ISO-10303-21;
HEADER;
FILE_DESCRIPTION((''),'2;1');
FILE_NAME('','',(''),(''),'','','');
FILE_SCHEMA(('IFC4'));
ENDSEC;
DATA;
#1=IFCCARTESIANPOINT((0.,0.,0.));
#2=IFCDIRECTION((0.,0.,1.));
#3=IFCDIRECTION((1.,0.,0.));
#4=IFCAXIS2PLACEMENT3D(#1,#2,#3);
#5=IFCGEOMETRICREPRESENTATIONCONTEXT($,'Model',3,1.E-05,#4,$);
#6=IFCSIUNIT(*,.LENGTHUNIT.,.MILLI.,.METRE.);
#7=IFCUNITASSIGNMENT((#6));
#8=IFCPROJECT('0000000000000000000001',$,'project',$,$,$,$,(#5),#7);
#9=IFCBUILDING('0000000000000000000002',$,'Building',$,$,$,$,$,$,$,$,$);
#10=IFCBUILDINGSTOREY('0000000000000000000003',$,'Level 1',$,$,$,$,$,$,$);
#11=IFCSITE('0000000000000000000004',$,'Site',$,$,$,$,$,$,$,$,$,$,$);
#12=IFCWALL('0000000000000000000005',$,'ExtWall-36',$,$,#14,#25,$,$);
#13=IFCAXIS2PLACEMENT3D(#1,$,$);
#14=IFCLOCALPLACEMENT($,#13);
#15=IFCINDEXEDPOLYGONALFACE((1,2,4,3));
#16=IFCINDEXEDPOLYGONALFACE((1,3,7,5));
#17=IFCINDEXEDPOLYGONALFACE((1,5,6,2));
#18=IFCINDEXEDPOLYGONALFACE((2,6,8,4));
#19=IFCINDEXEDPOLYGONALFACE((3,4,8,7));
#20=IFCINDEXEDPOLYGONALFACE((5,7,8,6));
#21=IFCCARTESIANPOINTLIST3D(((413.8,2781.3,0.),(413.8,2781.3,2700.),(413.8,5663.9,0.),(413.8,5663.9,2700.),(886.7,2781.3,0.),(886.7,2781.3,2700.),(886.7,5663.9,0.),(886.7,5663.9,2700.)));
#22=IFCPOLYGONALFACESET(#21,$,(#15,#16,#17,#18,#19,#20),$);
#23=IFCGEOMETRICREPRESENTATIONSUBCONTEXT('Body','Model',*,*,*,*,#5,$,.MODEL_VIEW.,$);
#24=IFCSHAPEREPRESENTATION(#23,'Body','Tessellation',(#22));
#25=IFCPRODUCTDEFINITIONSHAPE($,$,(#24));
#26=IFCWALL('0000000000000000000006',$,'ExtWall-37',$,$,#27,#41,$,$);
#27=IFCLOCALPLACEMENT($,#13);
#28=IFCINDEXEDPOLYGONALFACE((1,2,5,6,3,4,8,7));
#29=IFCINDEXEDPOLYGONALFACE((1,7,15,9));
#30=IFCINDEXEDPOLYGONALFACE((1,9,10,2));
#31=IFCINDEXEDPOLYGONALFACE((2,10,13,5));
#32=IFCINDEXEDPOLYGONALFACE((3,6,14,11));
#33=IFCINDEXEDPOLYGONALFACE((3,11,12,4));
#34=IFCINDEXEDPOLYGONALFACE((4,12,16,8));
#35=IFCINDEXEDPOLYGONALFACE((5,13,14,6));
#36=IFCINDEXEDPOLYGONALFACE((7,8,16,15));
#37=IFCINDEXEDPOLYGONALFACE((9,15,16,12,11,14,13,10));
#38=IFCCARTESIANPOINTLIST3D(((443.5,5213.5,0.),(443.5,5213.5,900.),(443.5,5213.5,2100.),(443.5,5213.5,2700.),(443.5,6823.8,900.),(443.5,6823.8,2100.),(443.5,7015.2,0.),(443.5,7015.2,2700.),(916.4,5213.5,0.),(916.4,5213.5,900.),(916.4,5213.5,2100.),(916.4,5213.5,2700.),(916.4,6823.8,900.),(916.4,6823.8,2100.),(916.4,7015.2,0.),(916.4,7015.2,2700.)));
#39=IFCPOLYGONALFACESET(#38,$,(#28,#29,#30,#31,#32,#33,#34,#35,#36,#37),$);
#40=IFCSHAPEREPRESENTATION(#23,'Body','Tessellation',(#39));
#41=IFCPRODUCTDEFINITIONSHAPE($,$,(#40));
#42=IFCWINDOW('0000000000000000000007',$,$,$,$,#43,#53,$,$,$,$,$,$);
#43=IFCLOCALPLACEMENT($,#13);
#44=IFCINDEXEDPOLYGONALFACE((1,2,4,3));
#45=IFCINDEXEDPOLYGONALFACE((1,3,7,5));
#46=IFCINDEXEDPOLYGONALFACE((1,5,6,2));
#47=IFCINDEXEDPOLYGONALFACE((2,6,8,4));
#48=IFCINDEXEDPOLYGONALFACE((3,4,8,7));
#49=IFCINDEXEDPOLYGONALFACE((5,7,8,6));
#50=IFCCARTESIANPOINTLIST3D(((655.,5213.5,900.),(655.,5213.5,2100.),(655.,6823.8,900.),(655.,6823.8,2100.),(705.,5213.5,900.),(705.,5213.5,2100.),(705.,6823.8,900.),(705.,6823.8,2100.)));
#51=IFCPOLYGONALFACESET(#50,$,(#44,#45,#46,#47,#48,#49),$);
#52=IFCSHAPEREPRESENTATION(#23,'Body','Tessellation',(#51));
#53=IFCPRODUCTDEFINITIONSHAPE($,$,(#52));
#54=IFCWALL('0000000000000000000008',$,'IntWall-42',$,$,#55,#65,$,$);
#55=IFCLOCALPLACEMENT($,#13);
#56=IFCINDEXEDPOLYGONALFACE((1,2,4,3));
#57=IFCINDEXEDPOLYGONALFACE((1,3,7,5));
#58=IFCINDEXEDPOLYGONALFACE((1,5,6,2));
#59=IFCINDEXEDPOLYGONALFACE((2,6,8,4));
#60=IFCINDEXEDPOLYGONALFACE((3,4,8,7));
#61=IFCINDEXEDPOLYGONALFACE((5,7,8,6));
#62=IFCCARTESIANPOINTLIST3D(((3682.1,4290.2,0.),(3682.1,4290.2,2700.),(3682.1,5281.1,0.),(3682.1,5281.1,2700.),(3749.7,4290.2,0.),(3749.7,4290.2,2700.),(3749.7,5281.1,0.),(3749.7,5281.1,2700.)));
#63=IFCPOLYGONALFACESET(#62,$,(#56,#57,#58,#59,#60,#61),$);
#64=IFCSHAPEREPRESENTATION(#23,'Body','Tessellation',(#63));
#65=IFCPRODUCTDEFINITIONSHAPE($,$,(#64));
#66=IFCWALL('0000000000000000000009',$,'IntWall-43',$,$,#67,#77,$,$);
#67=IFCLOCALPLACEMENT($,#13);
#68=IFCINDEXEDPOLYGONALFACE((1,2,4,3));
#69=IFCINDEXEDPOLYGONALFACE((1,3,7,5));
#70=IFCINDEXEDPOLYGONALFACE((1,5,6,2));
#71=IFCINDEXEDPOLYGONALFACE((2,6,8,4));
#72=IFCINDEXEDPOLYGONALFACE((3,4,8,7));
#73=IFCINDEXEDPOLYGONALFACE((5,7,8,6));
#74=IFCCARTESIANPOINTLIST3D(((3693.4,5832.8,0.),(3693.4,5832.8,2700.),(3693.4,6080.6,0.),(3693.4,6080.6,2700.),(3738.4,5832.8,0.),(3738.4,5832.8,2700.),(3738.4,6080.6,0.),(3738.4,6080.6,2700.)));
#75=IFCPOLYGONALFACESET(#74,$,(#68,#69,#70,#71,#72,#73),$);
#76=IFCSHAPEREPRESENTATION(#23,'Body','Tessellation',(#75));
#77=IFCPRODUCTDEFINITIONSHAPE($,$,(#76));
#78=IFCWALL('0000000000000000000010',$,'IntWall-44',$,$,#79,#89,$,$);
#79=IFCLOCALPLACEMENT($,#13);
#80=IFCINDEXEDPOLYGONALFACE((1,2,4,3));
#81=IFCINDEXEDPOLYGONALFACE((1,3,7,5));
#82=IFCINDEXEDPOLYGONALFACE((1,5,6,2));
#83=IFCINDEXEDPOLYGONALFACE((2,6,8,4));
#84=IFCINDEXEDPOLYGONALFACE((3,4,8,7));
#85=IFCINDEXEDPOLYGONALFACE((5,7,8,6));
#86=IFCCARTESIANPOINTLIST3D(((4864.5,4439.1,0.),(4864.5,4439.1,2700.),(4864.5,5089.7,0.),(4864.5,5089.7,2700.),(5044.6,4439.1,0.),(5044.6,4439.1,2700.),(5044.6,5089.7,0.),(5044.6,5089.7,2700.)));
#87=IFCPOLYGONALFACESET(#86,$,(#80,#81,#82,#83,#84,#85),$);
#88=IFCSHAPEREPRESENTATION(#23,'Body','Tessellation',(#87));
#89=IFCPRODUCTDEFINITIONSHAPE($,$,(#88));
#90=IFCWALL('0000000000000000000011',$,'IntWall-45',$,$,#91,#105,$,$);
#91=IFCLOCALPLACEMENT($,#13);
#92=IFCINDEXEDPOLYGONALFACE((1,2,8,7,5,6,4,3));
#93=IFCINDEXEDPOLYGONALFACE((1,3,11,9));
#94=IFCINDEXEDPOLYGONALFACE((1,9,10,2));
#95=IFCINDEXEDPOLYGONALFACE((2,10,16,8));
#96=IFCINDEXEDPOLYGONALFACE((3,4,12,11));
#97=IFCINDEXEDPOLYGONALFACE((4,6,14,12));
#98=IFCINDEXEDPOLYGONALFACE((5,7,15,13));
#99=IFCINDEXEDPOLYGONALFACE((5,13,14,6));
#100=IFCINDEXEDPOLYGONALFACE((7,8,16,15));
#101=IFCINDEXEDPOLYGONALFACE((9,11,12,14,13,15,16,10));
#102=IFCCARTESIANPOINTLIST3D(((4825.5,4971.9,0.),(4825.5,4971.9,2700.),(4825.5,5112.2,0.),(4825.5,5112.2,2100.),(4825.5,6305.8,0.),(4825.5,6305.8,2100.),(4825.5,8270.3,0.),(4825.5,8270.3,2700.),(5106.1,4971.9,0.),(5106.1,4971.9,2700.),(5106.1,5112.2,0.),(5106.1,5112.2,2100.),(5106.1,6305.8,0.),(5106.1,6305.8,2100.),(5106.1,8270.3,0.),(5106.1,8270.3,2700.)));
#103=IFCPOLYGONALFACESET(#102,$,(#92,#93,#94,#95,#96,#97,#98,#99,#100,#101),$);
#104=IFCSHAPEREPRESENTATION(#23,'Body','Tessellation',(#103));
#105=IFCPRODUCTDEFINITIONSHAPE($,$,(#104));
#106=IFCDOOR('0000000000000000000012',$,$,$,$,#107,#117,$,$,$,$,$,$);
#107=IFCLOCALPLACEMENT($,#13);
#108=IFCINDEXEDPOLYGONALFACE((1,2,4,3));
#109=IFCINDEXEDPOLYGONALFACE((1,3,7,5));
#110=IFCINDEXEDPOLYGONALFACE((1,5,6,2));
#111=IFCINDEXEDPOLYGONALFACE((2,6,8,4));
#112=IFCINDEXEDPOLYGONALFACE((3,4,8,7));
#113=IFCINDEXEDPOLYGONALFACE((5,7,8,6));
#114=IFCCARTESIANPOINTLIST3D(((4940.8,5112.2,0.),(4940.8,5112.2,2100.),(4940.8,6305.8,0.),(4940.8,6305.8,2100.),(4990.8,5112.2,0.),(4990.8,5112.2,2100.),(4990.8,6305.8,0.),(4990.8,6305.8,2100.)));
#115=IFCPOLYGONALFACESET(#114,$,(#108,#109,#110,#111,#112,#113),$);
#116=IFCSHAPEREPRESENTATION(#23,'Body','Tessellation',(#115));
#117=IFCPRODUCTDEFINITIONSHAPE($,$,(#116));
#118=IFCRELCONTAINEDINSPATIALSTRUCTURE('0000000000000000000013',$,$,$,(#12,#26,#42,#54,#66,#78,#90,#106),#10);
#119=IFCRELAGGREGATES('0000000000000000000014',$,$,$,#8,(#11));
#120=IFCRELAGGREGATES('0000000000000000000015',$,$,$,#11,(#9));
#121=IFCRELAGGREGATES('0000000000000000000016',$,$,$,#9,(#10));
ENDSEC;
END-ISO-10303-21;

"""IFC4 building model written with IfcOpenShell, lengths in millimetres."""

from ifc_helpers import new_model, si_unit, frame, origin_with_axes, place, context, subcontext, project, spatial, indexed_curve, outline, extrude, element, fill, save


model = new_model("IFC4")

# Units and contexts
model_context = context("Model", 3, precision=1e-05, world=origin_with_axes())
body_context = subcontext(model_context, "Body", "Model", "MODEL_VIEW")
ifc_project = project(units=[si_unit("LENGTHUNIT", "METRE", prefix="MILLI")], contexts=[model_context])

# Site, building, storey
site = spatial("IfcSite", under=ifc_project, Name="Site")
building = spatial("IfcBuilding", under=site, Name="Building")
storey = spatial("IfcBuildingStorey", under=building, Name="Level 1")

# Wall
wall_1_placement = place(None, frame((650.2, 2781.3, 0.0), z_axis=(0.0, 0.0, 1.0), x_axis=(0.0, 1.0, 0.0)))
element("IfcWall", 1, at=wall_1_placement, inside=storey, Name="ExtWall-36", context=body_context, shape_type="SweptSolid", body=[
    extrude(outline(indexed_curve([(0.0, 0.0), (0.0, 472.9), (2882.6, 472.9), (2882.6, 0.0), (0.0, 0.0)], self_intersect=False)), frame((0.0, -236.5, 0.0), z_axis=(0.0, 0.0, 1.0), x_axis=(1.0, 0.0, 0.0)), (0.0, 0.0, 1.0), 2700.0),
])

# Wall, opening, window
wall_2_placement = place(None, frame((680.0, 5213.5, 0.0), z_axis=(0.0, 0.0, 1.0), x_axis=(0.0, 1.0, 0.0)))
wall_2 = element("IfcWall", 2, at=wall_2_placement, inside=storey, Name="ExtWall-37", context=body_context, shape_type="SweptSolid", body=[
    extrude(outline(indexed_curve([(0.0, 0.0), (0.0, 472.9), (1801.7, 472.9), (1801.7, 0.0), (0.0, 0.0)], self_intersect=False)), frame((0.0, -236.5, 0.0), z_axis=(0.0, 0.0, 1.0), x_axis=(1.0, 0.0, 0.0)), (0.0, 0.0, 1.0), 2700.0),
])
opening_1_placement = place(wall_2_placement, frame((0.0, 0.0, 900.0), z_axis=(0.0, 0.0, 1.0), x_axis=(1.0, 0.0, 0.0)))
opening_1 = element("IfcOpeningElement", 3, at=opening_1_placement, cuts=wall_2, context=body_context, shape_type="SweptSolid", body=[
    extrude(outline(indexed_curve([(0.0, 0.0), (0.0, 572.9), (1610.2, 572.9), (1610.2, 0.0), (0.0, 0.0)], self_intersect=False)), frame((0.0, -286.5, 0.0), z_axis=(0.0, 0.0, 1.0), x_axis=(1.0, 0.0, 0.0)), (0.0, 0.0, 1.0), 1200.0),
])
window_1_placement = place(opening_1_placement, origin_with_axes())
window_1 = element("IfcWindow", 4, at=window_1_placement, inside=storey, context=body_context, shape_type="SweptSolid", body=[
    extrude(outline(indexed_curve([(0.0, 0.0), (0.0, 50.0), (1610.2, 50.0), (1610.2, 0.0), (0.0, 0.0)], self_intersect=False)), frame((0.0, -25.0, 0.0), z_axis=(0.0, 0.0, 1.0), x_axis=(1.0, 0.0, 0.0)), (0.0, 0.0, 1.0), 1200.0),
])
fill(opening_1, window_1)

# Walls
wall_3_placement = place(None, frame((3715.9, 4290.2, 0.0), z_axis=(0.0, 0.0, 1.0), x_axis=(0.0, 1.0, 0.0)))
element("IfcWall", 5, at=wall_3_placement, inside=storey, Name="IntWall-42", context=body_context, shape_type="SweptSolid", body=[
    extrude(outline(indexed_curve([(0.0, 0.0), (0.0, 67.6), (990.9, 67.6), (990.9, 0.0), (0.0, 0.0)], self_intersect=False)), frame((0.0, -33.8, 0.0), z_axis=(0.0, 0.0, 1.0), x_axis=(1.0, 0.0, 0.0)), (0.0, 0.0, 1.0), 2700.0),
])
wall_4_placement = place(None, frame((3715.9, 5832.8, 0.0), z_axis=(0.0, 0.0, 1.0), x_axis=(0.0, 1.0, 0.0)))
element("IfcWall", 6, at=wall_4_placement, inside=storey, Name="IntWall-43", context=body_context, shape_type="SweptSolid", body=[
    extrude(outline(indexed_curve([(0.0, 0.0), (0.0, 45.0), (247.7, 45.0), (247.7, 0.0), (0.0, 0.0)], self_intersect=False)), frame((0.0, -22.5, 0.0), z_axis=(0.0, 0.0, 1.0), x_axis=(1.0, 0.0, 0.0)), (0.0, 0.0, 1.0), 2700.0),
])
wall_5_placement = place(None, frame((4954.5, 4439.1, 0.0), z_axis=(0.0, 0.0, 1.0), x_axis=(0.0, 1.0, 0.0)))
element("IfcWall", 7, at=wall_5_placement, inside=storey, Name="IntWall-44", context=body_context, shape_type="SweptSolid", body=[
    extrude(outline(indexed_curve([(0.0, 0.0), (0.0, 180.2), (650.6, 180.2), (650.6, 0.0), (0.0, 0.0)], self_intersect=False)), frame((0.0, -90.1, 0.0), z_axis=(0.0, 0.0, 1.0), x_axis=(1.0, 0.0, 0.0)), (0.0, 0.0, 1.0), 2700.0),
])

# Wall, opening, door
wall_6_placement = place(None, frame((4965.8, 4971.9, 0.0), z_axis=(0.0, 0.0, 1.0), x_axis=(0.0, 1.0, 0.0)))
wall_6 = element("IfcWall", 8, at=wall_6_placement, inside=storey, Name="IntWall-45", context=body_context, shape_type="SweptSolid", body=[
    extrude(outline(indexed_curve([(0.0, 0.0), (0.0, 280.6), (3298.4, 280.6), (3298.4, 0.0), (0.0, 0.0)], self_intersect=False)), frame((0.0, -140.3, 0.0), z_axis=(0.0, 0.0, 1.0), x_axis=(1.0, 0.0, 0.0)), (0.0, 0.0, 1.0), 2700.0),
])
opening_2_placement = place(wall_6_placement, frame((140.3, 0.0, 0.0), z_axis=(0.0, 0.0, 1.0), x_axis=(1.0, 0.0, 0.0)))
opening_2 = element("IfcOpeningElement", 9, at=opening_2_placement, cuts=wall_6, context=body_context, shape_type="SweptSolid", body=[
    extrude(outline(indexed_curve([(0.0, 0.0), (0.0, 380.6), (1193.6, 380.6), (1193.6, 0.0), (0.0, 0.0)], self_intersect=False)), frame((0.0, -190.3, 0.0), z_axis=(0.0, 0.0, 1.0), x_axis=(1.0, 0.0, 0.0)), (0.0, 0.0, 1.0), 2100.0),
])
door_1_placement = place(opening_2_placement, origin_with_axes())
door_1 = element("IfcDoor", 10, at=door_1_placement, inside=storey, context=body_context, shape_type="SweptSolid", body=[
    extrude(outline(indexed_curve([(0.0, 0.0), (0.0, 50.0), (1193.6, 50.0), (1193.6, 0.0), (0.0, 0.0)], self_intersect=False)), frame((0.0, -25.0, 0.0), z_axis=(0.0, 0.0, 1.0), x_axis=(1.0, 0.0, 0.0)), (0.0, 0.0, 1.0), 2100.0),
])
fill(opening_2, door_1)

save(model, "model.ifc")
